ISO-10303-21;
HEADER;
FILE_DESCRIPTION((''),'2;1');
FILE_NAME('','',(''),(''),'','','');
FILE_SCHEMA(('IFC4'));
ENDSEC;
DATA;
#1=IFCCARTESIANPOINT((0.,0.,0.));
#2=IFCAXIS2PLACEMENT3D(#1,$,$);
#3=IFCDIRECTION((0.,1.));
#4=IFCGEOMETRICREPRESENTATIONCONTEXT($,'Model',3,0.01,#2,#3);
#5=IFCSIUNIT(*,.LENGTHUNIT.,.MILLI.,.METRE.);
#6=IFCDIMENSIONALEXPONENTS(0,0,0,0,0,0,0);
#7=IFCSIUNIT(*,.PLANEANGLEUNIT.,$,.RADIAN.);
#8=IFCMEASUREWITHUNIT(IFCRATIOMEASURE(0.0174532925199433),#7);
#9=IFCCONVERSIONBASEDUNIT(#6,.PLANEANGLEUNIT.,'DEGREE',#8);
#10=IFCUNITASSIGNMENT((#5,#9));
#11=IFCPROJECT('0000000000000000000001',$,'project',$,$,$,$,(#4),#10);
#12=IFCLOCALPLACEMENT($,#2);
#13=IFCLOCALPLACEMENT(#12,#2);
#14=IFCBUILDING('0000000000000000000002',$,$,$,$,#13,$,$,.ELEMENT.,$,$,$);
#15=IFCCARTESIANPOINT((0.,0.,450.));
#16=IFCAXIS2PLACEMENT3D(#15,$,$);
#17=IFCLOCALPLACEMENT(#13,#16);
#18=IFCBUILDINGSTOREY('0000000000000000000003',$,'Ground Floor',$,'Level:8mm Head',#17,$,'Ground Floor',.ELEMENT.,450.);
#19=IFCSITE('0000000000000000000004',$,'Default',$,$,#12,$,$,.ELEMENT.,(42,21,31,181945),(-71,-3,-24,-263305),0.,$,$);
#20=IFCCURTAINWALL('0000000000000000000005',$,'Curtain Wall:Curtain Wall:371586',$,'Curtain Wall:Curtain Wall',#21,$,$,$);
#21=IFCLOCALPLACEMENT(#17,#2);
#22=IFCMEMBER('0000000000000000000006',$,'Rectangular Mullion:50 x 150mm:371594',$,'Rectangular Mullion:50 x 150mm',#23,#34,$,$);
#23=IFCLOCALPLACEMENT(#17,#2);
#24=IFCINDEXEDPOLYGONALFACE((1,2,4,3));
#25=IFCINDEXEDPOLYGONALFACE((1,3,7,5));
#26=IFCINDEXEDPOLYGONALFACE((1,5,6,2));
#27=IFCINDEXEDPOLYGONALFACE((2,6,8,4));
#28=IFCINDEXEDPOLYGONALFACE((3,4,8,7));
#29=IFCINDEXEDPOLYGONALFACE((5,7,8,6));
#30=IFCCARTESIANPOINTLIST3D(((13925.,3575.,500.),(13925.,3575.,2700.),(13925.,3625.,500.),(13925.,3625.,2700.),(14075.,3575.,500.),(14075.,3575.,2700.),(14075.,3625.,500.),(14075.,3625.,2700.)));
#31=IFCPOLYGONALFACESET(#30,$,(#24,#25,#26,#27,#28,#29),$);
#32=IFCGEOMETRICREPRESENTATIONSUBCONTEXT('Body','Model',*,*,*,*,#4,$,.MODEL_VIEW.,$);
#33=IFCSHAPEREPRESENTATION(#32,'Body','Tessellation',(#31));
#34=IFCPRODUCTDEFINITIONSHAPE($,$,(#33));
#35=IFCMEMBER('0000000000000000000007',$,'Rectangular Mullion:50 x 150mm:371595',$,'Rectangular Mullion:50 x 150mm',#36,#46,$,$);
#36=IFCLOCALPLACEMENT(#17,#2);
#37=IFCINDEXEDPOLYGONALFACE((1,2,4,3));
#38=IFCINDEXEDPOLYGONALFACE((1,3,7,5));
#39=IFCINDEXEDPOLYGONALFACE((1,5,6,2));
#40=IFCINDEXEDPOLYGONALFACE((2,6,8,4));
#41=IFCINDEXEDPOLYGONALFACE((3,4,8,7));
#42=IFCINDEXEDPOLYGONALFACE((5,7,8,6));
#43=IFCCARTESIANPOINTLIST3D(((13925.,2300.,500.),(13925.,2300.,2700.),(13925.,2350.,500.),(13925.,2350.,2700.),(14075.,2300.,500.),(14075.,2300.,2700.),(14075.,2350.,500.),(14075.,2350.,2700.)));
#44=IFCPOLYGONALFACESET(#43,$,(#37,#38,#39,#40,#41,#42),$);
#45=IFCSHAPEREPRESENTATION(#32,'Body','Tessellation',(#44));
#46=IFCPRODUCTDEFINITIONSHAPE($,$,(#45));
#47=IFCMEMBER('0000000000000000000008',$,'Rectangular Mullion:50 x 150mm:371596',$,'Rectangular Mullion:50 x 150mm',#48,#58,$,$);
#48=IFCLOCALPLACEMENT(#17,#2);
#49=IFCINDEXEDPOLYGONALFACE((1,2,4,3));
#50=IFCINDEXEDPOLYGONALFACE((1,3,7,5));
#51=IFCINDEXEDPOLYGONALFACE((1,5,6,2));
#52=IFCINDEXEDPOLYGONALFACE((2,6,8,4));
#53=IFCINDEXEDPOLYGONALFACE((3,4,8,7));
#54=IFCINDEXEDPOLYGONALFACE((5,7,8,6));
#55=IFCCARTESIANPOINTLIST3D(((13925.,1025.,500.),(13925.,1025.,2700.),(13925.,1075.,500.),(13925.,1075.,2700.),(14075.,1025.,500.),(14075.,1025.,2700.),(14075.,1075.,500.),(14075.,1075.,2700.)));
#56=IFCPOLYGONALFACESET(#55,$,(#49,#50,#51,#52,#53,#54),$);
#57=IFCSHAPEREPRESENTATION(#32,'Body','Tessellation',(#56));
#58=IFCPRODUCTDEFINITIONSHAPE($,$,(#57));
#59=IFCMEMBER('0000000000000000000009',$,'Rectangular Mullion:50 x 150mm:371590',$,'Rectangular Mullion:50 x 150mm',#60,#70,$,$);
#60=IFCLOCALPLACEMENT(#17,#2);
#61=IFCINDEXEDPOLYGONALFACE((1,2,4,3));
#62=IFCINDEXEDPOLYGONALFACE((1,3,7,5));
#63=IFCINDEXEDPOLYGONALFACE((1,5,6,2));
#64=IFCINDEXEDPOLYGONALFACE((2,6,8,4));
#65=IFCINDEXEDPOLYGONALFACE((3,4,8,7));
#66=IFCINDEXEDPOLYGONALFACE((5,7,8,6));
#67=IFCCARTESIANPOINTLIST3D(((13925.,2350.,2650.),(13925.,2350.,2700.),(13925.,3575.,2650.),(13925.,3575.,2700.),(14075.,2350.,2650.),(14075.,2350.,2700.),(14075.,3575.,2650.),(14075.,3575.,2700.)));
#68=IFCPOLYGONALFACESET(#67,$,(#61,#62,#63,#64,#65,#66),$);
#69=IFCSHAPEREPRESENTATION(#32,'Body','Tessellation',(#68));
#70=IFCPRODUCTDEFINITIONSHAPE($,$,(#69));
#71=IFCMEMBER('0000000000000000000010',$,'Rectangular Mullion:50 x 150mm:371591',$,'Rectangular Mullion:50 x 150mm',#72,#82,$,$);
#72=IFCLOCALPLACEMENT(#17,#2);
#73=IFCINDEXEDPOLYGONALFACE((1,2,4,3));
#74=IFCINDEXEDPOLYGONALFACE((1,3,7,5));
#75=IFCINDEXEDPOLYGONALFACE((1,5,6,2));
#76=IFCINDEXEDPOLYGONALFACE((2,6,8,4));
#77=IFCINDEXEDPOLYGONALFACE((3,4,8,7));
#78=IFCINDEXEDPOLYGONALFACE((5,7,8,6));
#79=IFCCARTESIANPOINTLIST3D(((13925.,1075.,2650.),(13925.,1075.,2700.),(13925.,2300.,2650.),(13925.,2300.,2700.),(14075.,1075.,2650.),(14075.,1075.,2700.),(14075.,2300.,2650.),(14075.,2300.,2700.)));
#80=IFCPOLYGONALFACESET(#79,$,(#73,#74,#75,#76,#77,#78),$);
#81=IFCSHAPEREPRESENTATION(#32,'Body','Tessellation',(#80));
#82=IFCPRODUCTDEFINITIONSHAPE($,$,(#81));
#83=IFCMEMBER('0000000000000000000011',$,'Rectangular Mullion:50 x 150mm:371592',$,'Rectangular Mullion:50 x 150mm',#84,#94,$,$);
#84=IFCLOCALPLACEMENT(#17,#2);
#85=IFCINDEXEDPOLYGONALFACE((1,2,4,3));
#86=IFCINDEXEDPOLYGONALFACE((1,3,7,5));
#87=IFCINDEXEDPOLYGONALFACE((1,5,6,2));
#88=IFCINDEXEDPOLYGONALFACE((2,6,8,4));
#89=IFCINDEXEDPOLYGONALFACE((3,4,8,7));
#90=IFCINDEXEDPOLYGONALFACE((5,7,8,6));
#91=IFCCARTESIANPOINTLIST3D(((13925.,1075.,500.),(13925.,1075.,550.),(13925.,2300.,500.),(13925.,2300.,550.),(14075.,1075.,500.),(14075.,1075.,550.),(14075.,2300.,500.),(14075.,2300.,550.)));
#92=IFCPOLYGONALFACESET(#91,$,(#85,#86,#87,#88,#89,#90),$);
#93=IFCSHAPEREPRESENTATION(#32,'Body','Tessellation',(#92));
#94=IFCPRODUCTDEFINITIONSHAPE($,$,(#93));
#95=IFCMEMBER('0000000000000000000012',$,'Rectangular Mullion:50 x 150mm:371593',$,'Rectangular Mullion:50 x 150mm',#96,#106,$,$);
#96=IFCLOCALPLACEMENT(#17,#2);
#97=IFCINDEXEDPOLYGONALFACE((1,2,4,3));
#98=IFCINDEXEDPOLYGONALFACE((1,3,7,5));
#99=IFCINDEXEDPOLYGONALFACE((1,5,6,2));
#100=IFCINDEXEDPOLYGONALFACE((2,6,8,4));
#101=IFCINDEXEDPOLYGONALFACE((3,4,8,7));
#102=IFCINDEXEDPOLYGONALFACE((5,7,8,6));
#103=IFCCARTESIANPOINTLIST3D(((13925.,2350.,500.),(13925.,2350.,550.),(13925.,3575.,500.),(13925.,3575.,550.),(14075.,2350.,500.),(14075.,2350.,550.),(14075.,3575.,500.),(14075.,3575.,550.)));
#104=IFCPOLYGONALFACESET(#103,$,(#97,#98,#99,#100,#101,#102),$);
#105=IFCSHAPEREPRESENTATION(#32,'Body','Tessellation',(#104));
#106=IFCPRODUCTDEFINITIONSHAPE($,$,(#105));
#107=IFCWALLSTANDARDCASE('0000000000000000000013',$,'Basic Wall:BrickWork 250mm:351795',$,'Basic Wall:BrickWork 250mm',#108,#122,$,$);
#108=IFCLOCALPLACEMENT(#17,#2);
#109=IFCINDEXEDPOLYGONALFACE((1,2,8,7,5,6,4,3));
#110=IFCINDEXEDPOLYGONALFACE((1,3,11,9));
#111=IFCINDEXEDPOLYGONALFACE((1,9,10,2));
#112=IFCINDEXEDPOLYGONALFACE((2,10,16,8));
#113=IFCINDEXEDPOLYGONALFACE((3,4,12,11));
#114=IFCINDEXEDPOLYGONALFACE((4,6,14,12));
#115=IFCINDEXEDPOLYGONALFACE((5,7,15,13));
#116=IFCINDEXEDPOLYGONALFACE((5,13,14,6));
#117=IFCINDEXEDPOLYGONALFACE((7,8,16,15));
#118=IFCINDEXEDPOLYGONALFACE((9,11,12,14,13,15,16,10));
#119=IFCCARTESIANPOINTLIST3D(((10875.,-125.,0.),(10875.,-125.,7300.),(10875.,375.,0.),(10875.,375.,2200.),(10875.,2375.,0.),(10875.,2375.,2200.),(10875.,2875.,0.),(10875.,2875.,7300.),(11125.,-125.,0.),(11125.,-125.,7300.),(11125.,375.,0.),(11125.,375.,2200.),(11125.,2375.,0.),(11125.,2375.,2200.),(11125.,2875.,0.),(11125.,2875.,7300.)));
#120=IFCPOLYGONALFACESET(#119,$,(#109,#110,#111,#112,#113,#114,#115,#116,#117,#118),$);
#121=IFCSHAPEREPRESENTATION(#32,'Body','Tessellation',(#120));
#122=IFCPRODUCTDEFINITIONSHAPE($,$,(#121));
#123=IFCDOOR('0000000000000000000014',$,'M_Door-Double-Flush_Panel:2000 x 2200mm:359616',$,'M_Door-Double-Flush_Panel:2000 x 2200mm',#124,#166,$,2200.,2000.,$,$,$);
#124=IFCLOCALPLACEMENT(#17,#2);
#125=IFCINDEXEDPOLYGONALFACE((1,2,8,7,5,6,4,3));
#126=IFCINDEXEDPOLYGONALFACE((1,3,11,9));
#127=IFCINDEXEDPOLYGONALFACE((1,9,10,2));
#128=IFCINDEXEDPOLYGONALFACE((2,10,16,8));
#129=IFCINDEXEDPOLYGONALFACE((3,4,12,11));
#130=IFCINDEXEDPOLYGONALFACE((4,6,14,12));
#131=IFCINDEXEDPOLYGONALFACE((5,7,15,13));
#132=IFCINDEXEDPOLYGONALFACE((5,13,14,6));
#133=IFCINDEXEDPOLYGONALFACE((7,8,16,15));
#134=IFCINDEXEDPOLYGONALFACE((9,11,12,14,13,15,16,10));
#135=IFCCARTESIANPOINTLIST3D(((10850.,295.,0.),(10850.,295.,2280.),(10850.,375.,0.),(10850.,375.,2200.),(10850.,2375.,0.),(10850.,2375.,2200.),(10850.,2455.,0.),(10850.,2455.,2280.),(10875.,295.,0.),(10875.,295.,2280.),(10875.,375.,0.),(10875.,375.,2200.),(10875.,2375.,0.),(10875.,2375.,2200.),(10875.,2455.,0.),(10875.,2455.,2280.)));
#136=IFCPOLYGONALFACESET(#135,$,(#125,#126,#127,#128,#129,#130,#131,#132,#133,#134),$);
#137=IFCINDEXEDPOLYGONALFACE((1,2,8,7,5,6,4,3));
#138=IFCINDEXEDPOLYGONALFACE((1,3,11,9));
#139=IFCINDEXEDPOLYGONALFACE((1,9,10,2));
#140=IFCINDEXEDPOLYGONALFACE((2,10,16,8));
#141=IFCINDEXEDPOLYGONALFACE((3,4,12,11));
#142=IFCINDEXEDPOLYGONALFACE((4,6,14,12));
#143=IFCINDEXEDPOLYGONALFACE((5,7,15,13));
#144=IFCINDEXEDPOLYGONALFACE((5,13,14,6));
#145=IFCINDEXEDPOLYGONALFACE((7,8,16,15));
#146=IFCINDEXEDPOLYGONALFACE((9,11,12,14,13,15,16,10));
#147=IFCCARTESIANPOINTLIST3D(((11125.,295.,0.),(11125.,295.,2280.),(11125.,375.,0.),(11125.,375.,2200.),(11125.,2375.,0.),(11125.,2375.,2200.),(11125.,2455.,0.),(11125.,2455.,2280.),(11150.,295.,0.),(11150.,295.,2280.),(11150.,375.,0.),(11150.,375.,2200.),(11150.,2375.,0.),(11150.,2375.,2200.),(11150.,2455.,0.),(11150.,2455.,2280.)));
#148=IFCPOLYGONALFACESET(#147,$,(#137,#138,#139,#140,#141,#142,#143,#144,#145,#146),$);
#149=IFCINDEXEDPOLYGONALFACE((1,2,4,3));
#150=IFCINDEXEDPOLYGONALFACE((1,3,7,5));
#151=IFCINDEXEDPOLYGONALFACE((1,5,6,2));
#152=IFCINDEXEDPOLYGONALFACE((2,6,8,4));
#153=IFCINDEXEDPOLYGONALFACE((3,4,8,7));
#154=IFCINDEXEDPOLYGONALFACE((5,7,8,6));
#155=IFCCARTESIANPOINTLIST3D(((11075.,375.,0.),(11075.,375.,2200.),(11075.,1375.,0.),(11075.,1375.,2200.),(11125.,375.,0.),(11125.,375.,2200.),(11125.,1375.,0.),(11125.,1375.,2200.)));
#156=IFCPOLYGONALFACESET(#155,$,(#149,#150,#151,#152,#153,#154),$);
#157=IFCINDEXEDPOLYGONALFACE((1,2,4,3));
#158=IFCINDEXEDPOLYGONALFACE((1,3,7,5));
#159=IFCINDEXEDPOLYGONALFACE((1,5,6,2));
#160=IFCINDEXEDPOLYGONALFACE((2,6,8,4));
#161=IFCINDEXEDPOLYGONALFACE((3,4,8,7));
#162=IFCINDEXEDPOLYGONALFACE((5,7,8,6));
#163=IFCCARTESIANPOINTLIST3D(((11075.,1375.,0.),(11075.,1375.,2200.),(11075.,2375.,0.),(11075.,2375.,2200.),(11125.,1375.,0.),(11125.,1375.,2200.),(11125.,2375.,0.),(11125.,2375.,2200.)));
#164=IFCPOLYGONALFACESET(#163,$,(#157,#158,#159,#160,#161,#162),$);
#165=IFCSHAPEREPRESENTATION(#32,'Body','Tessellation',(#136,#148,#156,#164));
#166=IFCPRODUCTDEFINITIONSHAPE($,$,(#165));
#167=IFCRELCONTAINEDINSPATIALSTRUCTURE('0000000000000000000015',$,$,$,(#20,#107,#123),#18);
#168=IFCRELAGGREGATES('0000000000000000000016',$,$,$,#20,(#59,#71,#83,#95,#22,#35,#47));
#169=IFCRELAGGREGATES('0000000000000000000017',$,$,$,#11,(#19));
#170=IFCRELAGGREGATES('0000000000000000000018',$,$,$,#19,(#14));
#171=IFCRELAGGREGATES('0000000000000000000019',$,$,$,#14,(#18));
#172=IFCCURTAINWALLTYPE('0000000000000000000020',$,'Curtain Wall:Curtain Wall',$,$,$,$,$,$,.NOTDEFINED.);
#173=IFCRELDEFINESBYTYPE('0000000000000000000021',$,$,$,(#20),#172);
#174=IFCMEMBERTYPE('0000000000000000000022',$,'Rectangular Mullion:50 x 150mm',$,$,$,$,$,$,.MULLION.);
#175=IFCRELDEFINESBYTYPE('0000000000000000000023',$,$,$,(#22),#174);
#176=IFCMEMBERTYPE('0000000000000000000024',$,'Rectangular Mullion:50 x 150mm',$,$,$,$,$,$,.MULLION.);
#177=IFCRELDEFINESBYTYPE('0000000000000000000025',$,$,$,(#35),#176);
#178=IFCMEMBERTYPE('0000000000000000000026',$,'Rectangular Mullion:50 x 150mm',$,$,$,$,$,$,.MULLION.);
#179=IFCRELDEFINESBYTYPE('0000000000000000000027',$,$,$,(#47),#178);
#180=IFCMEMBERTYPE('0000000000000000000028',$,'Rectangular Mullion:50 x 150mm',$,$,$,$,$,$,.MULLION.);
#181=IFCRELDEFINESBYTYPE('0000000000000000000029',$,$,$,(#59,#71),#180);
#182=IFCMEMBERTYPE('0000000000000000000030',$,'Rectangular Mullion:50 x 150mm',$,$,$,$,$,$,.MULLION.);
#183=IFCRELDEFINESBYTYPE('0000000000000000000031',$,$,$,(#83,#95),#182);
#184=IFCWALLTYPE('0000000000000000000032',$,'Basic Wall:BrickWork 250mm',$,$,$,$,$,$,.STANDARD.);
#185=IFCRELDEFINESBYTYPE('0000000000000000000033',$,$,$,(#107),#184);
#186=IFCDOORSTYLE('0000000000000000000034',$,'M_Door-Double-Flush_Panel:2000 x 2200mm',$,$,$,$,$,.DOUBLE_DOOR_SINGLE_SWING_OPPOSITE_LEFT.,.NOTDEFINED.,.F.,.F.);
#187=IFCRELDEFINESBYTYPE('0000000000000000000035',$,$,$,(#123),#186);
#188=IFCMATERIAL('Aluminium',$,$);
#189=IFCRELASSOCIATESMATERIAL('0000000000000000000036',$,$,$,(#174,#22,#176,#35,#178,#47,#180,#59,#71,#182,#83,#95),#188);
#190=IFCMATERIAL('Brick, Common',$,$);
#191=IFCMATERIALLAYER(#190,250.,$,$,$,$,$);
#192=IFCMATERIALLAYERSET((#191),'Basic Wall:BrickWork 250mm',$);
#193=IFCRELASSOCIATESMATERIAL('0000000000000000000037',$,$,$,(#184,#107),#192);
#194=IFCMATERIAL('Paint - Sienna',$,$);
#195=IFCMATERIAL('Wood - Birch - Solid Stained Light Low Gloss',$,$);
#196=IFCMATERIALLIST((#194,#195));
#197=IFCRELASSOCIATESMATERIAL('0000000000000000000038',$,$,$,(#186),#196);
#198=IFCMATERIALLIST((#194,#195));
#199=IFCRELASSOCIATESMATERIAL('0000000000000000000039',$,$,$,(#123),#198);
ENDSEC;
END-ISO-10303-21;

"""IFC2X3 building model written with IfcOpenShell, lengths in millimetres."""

from ifc_helpers import new_model, entity, si_unit, converted_unit, direction, frame, frame_2d, origin, origin_2d_with_axis, place, context, subcontext, project, spatial, polyline, rectangle, outline, extrude, source, transform, mapped, material, material_list, layer, layer_set, layer_usage, type_object, type_shapes, element, fill, aggregate, save


model = new_model("IFC2X3")

# Units and contexts
model_context = context("Model", 3, precision=0.01, world=origin(), true_north=direction((0.0, 1.0)))
body_context = subcontext(model_context, "Body", "Model", "MODEL_VIEW")
ifc_project = project(units=[si_unit("LENGTHUNIT", "METRE", prefix="MILLI"), converted_unit("PLANEANGLEUNIT", "DEGREE", entity("IfcRatioMeasure", 0.0174532925199433), si_unit("PLANEANGLEUNIT", "RADIAN"), dimensions=[0, 0, 0, 0, 0, 0, 0])], contexts=[model_context])

# Site, building, storey
site_placement = place(None, origin())
site = spatial("IfcSite", under=ifc_project, at=site_placement, Name="Default", CompositionType="ELEMENT", RefLatitude=(42, 21, 31, 181945), RefLongitude=(-71, -3, -24, -263305), RefElevation=0.0)
building_placement = place(site_placement, origin())
building = spatial("IfcBuilding", under=site, at=building_placement, CompositionType="ELEMENT")
storey_placement = place(building_placement, frame((0.0, 0.0, 450.0)))
storey = spatial("IfcBuildingStorey", under=building, at=storey_placement, Name="Ground Floor", ObjectType="Level:8mm Head", LongName="Ground Floor", CompositionType="ELEMENT", Elevation=450.0)

# Curtain wall, members
curtain_wall_type = type_object("IfcCurtainWallType", Name="Curtain Wall:Curtain Wall", PredefinedType="NOTDEFINED")
curtain_wall_placement = place(storey_placement, frame((0.0, 0.0, -450.0)))
curtain_wall = element("IfcCurtainWall", 1, at=curtain_wall_placement, inside=storey, type_object=curtain_wall_type, Name="Curtain Wall:Curtain Wall:371586", ObjectType="Curtain Wall:Curtain Wall")
ifc_material_1 = material(Name="Aluminium")
member_type_1 = type_object("IfcMemberType", Name="Rectangular Mullion:50 x 150mm", PredefinedType="MULLION", material=ifc_material_1)
shared_shape_1 = source(origin(), body_context, "Body", "SweptSolid", [
    extrude(rectangle(XDim=150.0, YDim=50.0, at=origin_2d_with_axis()), frame((-25.0, 0.0, -2200.0), z_axis=(0.0, 0.0, 1.0), x_axis=(0.0, -1.0, 0.0)), (0.0, 0.0, 1.0), 2200.0),
])
type_shapes(member_type_1, [shared_shape_1])
member_1_placement = place(storey_placement, frame((14000.0, 3625.0, 500.0), z_axis=(0.0, 0.0, -1.0), x_axis=(0.0, 1.0, 0.0)))
member_1 = element("IfcMember", 2, at=member_1_placement, type_object=member_type_1, material=ifc_material_1, Name="Rectangular Mullion:50 x 150mm:371594", ObjectType="Rectangular Mullion:50 x 150mm", context=body_context, shape_type="MappedRepresentation", body=[
    mapped(shared_shape_1, transform((0.0, 0.0, 0.0), scale=1.0)),
])
member_type_2 = type_object("IfcMemberType", Name="Rectangular Mullion:50 x 150mm", PredefinedType="MULLION", material=ifc_material_1)
shared_shape_2 = source(origin(), body_context, "Body", "SweptSolid", [
    extrude(rectangle(XDim=150.0, YDim=50.0, at=origin_2d_with_axis()), frame((0.0, 0.0, -2200.0), z_axis=(0.0, 0.0, 1.0), x_axis=(0.0, -1.0, 0.0)), (0.0, 0.0, 1.0), 2200.0),
])
type_shapes(member_type_2, [shared_shape_2])
member_2_placement = place(storey_placement, frame((14000.0, 2325.0, 500.0), z_axis=(0.0, 0.0, -1.0), x_axis=(0.0, 1.0, 0.0)))
member_2 = element("IfcMember", 3, at=member_2_placement, type_object=member_type_2, material=ifc_material_1, Name="Rectangular Mullion:50 x 150mm:371595", ObjectType="Rectangular Mullion:50 x 150mm", context=body_context, shape_type="MappedRepresentation", body=[
    mapped(shared_shape_2, transform((0.0, 0.0, 0.0), scale=1.0)),
])
member_type_3 = type_object("IfcMemberType", Name="Rectangular Mullion:50 x 150mm", PredefinedType="MULLION", material=ifc_material_1)
shared_shape_3 = source(origin(), body_context, "Body", "SweptSolid", [
    extrude(rectangle(XDim=150.0, YDim=50.0, at=origin_2d_with_axis()), frame((-25.0, 0.0, -2200.0), z_axis=(0.0, 0.0, 1.0), x_axis=(0.0, -1.0, 0.0)), (0.0, 0.0, 1.0), 2200.0),
])
type_shapes(member_type_3, [shared_shape_3])
member_3_placement = place(storey_placement, frame((14000.0, 1025.0, 2700.0), z_axis=(0.0, 0.0, 1.0), x_axis=(0.0, -1.0, 0.0)))
member_3 = element("IfcMember", 4, at=member_3_placement, type_object=member_type_3, material=ifc_material_1, Name="Rectangular Mullion:50 x 150mm:371596", ObjectType="Rectangular Mullion:50 x 150mm", context=body_context, shape_type="MappedRepresentation", body=[
    mapped(shared_shape_3, transform((0.0, 0.0, 0.0), scale=1.0)),
])
member_type_4 = type_object("IfcMemberType", Name="Rectangular Mullion:50 x 150mm", PredefinedType="MULLION", material=ifc_material_1)
shared_shape_4 = source(origin(), body_context, "Body", "SweptSolid", [
    extrude(rectangle(XDim=150.0, YDim=50.0, at=origin_2d_with_axis()), frame((-25.0, 0.0, -1225.0), z_axis=(0.0, 0.0, 1.0), x_axis=(0.0, -1.0, 0.0)), (0.0, 0.0, 1.0), 1225.0),
])
type_shapes(member_type_4, [shared_shape_4])
member_4_placement = place(storey_placement, frame((14000.0, 3575.0, 2700.0), z_axis=(0.0, 1.0, 0.0), x_axis=(0.0, 0.0, 1.0)))
member_4 = element("IfcMember", 5, at=member_4_placement, type_object=member_type_4, material=ifc_material_1, Name="Rectangular Mullion:50 x 150mm:371590", ObjectType="Rectangular Mullion:50 x 150mm", context=body_context, shape_type="MappedRepresentation", body=[
    mapped(shared_shape_4, transform((0.0, 0.0, 0.0), scale=1.0)),
])
member_5_placement = place(storey_placement, frame((14000.0, 2300.0, 2700.0), z_axis=(0.0, 1.0, 0.0), x_axis=(0.0, 0.0, 1.0)))
member_5 = element("IfcMember", 6, at=member_5_placement, type_object=member_type_4, material=ifc_material_1, Name="Rectangular Mullion:50 x 150mm:371591", ObjectType="Rectangular Mullion:50 x 150mm", context=body_context, shape_type="MappedRepresentation", body=[
    mapped(shared_shape_4, transform((0.0, 0.0, 0.0), scale=1.0)),
])
member_type_5 = type_object("IfcMemberType", Name="Rectangular Mullion:50 x 150mm", PredefinedType="MULLION", material=ifc_material_1)
shared_shape_5 = source(origin(), body_context, "Body", "SweptSolid", [
    extrude(rectangle(XDim=150.0, YDim=50.0, at=origin_2d_with_axis()), frame((-25.0, 0.0, -1225.0), z_axis=(0.0, 0.0, 1.0), x_axis=(0.0, -1.0, 0.0)), (0.0, 0.0, 1.0), 1225.0),
])
type_shapes(member_type_5, [shared_shape_5])
member_6_placement = place(storey_placement, frame((14000.0, 1075.0, 500.0), z_axis=(0.0, -1.0, 0.0), x_axis=(0.0, 0.0, -1.0)))
member_6 = element("IfcMember", 7, at=member_6_placement, type_object=member_type_5, material=ifc_material_1, Name="Rectangular Mullion:50 x 150mm:371592", ObjectType="Rectangular Mullion:50 x 150mm", context=body_context, shape_type="MappedRepresentation", body=[
    mapped(shared_shape_5, transform((0.0, 0.0, 0.0), scale=1.0)),
])
member_7_placement = place(storey_placement, frame((14000.0, 2350.0, 500.0), z_axis=(0.0, -1.0, 0.0), x_axis=(0.0, 0.0, -1.0)))
member_7 = element("IfcMember", 8, at=member_7_placement, type_object=member_type_5, material=ifc_material_1, Name="Rectangular Mullion:50 x 150mm:371593", ObjectType="Rectangular Mullion:50 x 150mm", context=body_context, shape_type="MappedRepresentation", body=[
    mapped(shared_shape_5, transform((0.0, 0.0, 0.0), scale=1.0)),
])
aggregate(curtain_wall, [member_4, member_5, member_6, member_7, member_1, member_2, member_3])

# Wall, opening, door
ifc_material_2 = material(Name="Brick, Common")
ifc_layer_1 = layer(ifc_material_2, 250.0)
ifc_layer_set_1 = layer_set([ifc_layer_1], Name="Basic Wall:BrickWork 250mm")
ifc_layer_usage_1 = layer_usage(ifc_layer_set_1, "AXIS2", "POSITIVE", -125.0)
wall_type_1 = type_object("IfcWallType", Name="Basic Wall:BrickWork 250mm", PredefinedType="STANDARD", material=ifc_layer_set_1)
wall_1_placement = place(storey_placement, frame((11000.0, 2875.0, 0.0), z_axis=(0.0, 0.0, 1.0), x_axis=(0.0, -1.0, 0.0)))
wall_1 = element("IfcWallStandardCase", 9, at=wall_1_placement, inside=storey, type_object=wall_type_1, material=ifc_layer_usage_1, Name="Basic Wall:BrickWork 250mm:351795", ObjectType="Basic Wall:BrickWork 250mm", context=body_context, shape_type="SweptSolid", body=[
    extrude(rectangle(XDim=3000.0, YDim=250.0, at=frame_2d((1500.0, 0.0), x_axis=(-1.0, 0.0))), origin(), (0.0, 0.0, 1.0), 7300.0),
])
opening_1_placement = place(wall_1_placement, frame((500.0, -125.0, 0.0)))
opening_1 = element("IfcOpeningElement", 10, at=opening_1_placement, cuts=wall_1, ObjectType="Opening", context=body_context, shape_type="SweptSolid", body=[
    extrude(rectangle(XDim=2200.0, YDim=2000.0, at=frame_2d((1100.0, 1000.0), x_axis=(1.0, 0.0))), frame((0.0, 0.0, 0.0), z_axis=(0.0, 1.0, 0.0), x_axis=(0.0, 0.0, 1.0)), (0.0, 0.0, 1.0), 250.0),
])
ifc_material_3 = material(Name="Paint - Sienna")
ifc_material_4 = material(Name="Wood - Birch - Solid Stained Light Low Gloss")
ifc_material_list_1 = material_list([ifc_material_3, ifc_material_4])
ifc_material_list_2 = material_list([ifc_material_3, ifc_material_4])
door_style_1 = type_object("IfcDoorStyle", Name="M_Door-Double-Flush_Panel:2000 x 2200mm", ConstructionType="NOTDEFINED", OperationType="DOUBLE_DOOR_SINGLE_SWING_OPPOSITE_LEFT", ParameterTakesPrecedence=False, Sizeable=False, material=ifc_material_list_2)
shared_shape_6 = source(origin(), body_context, "Body", "SweptSolid", [
    extrude(outline(polyline([(-1080.0, 1000.0), (1120.0, 1000.0), (1120.0, 1080.0), (-1160.0, 1080.0), (-1160.0, -1080.0), (1120.0, -1080.0), (1120.0, -1000.0), (-1080.0, -1000.0), (-1080.0, 1000.0)])), frame((1000.0, -25.0, 1120.0), z_axis=(0.0, 1.0, 0.0), x_axis=(0.0, 0.0, -1.0)), (0.0, 0.0, 1.0), 25.0),
    extrude(outline(polyline([(-1080.0, 1000.0), (1120.0, 1000.0), (1120.0, 1080.0), (-1160.0, 1080.0), (-1160.0, -1080.0), (1120.0, -1080.0), (1120.0, -1000.0), (-1080.0, -1000.0), (-1080.0, 1000.0)])), frame((1000.0, 250.0, 1120.0), z_axis=(0.0, 1.0, 0.0), x_axis=(0.0, 0.0, -1.0)), (0.0, 0.0, 1.0), 25.0),
    extrude(rectangle(XDim=50.0, YDim=1000.0, at=frame_2d((0.0, 0.0), x_axis=(1.0, 0.0))), frame((1500.0, 225.0, 0.0), z_axis=(0.0, 0.0, 1.0), x_axis=(0.0, -1.0, 0.0)), (0.0, 0.0, 1.0), 2200.0),
    extrude(rectangle(XDim=50.0, YDim=1000.0, at=frame_2d((0.0, 0.0), x_axis=(1.0, 0.0))), frame((500.0, 225.0, 0.0), z_axis=(0.0, 0.0, 1.0), x_axis=(0.0, -1.0, 0.0)), (0.0, 0.0, 1.0), 2200.0),
])
type_shapes(door_style_1, [shared_shape_6])
door_1_placement = place(opening_1_placement, origin())
door_1 = element("IfcDoor", 11, at=door_1_placement, inside=storey, type_object=door_style_1, material=ifc_material_list_1, Name="M_Door-Double-Flush_Panel:2000 x 2200mm:359616", ObjectType="M_Door-Double-Flush_Panel:2000 x 2200mm", OverallHeight=2200.0, OverallWidth=2000.0, context=body_context, shape_type="MappedRepresentation", body=[
    mapped(shared_shape_6, transform((0.0, 0.0, 0.0), scale=1.0)),
])
fill(opening_1, door_1)

save(model, "model.ifc")
